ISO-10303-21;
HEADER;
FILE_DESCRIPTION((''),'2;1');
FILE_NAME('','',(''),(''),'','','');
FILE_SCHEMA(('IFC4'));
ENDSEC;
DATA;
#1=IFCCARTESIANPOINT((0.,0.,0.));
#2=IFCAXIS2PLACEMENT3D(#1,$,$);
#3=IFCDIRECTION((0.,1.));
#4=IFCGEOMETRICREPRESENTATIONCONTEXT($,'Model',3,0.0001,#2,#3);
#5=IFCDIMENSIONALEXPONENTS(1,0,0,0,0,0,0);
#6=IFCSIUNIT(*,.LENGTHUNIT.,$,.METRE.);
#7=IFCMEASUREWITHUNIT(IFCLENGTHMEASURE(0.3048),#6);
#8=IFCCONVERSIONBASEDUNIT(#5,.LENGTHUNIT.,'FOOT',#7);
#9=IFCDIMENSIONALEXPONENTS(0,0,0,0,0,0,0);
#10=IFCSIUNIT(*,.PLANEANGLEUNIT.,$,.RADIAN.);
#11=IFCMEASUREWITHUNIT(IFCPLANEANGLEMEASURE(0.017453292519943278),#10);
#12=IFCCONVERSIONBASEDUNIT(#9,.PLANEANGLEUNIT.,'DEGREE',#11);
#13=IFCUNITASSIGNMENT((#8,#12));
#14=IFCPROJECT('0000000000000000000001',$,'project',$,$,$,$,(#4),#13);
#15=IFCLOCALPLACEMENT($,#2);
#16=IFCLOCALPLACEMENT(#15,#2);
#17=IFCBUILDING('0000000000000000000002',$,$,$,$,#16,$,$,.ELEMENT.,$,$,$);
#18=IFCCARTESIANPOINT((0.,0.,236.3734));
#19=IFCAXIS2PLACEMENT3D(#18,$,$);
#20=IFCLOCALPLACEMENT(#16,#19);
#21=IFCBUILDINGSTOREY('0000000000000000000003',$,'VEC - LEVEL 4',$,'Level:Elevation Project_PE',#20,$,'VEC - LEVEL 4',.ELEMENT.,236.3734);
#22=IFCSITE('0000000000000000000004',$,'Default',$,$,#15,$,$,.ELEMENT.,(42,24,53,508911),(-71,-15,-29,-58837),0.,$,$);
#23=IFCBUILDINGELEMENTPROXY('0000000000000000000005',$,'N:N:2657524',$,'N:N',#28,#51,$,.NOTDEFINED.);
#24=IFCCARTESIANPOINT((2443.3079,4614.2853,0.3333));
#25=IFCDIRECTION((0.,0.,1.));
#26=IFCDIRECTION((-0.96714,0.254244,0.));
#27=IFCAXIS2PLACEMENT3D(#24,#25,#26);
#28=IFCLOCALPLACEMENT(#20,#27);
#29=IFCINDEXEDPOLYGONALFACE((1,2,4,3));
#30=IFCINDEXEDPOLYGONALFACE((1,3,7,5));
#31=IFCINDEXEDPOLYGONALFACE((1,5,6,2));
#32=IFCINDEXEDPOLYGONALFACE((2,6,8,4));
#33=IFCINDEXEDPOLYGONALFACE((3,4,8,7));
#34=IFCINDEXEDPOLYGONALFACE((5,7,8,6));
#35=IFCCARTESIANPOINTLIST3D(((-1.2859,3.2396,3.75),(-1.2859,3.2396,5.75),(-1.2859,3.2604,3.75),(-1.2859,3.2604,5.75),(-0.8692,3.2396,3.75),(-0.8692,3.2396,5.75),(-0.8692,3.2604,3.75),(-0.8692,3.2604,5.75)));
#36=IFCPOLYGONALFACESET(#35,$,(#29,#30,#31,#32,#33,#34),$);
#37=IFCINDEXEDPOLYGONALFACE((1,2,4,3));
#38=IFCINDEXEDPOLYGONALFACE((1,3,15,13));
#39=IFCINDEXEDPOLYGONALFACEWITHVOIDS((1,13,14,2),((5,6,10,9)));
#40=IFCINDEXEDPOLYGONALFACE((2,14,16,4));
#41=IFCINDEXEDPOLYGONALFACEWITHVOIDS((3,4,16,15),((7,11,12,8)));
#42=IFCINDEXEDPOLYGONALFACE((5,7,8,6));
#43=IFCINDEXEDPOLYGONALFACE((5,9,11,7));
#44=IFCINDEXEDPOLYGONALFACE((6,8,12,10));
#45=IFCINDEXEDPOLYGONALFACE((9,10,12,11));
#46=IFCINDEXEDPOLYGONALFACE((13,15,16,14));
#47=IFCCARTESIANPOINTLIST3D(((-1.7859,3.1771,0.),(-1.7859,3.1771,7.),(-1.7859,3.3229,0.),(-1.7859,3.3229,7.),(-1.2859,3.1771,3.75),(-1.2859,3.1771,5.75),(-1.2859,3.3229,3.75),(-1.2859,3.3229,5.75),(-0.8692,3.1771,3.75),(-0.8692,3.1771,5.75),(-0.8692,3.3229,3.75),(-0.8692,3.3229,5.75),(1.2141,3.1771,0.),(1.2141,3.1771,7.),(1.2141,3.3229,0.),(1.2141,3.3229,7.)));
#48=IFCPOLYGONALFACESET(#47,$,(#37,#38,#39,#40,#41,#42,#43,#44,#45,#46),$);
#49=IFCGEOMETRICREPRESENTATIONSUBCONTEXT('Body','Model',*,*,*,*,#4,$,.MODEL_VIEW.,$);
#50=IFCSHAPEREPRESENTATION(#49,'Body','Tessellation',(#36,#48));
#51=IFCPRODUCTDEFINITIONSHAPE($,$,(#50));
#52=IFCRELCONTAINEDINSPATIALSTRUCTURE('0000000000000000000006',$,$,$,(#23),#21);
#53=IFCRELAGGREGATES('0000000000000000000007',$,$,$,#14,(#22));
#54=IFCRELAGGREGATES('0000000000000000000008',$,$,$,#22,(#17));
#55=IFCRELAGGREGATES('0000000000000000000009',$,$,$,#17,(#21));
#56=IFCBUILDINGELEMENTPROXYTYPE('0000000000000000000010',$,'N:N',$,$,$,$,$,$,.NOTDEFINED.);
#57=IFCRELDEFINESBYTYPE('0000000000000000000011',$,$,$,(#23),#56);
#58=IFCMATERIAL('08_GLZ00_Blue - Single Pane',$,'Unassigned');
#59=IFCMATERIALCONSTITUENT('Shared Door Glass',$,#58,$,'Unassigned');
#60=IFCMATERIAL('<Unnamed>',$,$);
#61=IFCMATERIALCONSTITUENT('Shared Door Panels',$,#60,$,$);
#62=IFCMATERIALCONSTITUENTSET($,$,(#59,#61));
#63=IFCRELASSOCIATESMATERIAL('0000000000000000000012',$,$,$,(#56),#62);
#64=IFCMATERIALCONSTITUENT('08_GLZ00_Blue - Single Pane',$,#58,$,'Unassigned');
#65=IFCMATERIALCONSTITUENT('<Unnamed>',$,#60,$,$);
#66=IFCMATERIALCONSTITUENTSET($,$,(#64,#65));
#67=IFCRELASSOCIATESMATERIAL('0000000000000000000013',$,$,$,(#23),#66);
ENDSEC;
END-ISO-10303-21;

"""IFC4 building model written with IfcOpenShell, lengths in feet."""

from ifc_helpers import new_model, entity, si_unit, converted_unit, direction, frame, origin, place, context, subcontext, project, spatial, indexed_curve, outline, extrude, source, transform, mapped, material, constituent, constituent_set, type_object, type_shapes, element, save


model = new_model("IFC4")

# Units and contexts
model_context = context("Model", 3, precision=0.0001, world=origin(), true_north=direction((0.0, 1.0)))
body_context = subcontext(model_context, "Body", "Model", "MODEL_VIEW")
ifc_project = project(units=[converted_unit("LENGTHUNIT", "FOOT", entity("IfcLengthMeasure", 0.3048), si_unit("LENGTHUNIT", "METRE"), dimensions=[1, 0, 0, 0, 0, 0, 0]), converted_unit("PLANEANGLEUNIT", "DEGREE", entity("IfcPlaneAngleMeasure", 0.017453292519943278), si_unit("PLANEANGLEUNIT", "RADIAN"), dimensions=[0, 0, 0, 0, 0, 0, 0])], contexts=[model_context])

# Site, building, storey
site_placement = place(None, origin())
site = spatial("IfcSite", under=ifc_project, at=site_placement, Name="Default", CompositionType="ELEMENT", RefLatitude=(42, 24, 53, 508911), RefLongitude=(-71, -15, -29, -58837), RefElevation=0.0)
building_placement = place(site_placement, origin())
building = spatial("IfcBuilding", under=site, at=building_placement, CompositionType="ELEMENT")
storey_placement = place(building_placement, frame((0.0, 0.0, 236.3734)))
storey = spatial("IfcBuildingStorey", under=building, at=storey_placement, Name="VEC - LEVEL 4", ObjectType="Level:Elevation Project_PE", LongName="VEC - LEVEL 4", CompositionType="ELEMENT", Elevation=236.3734)

# Shared definitions
ifc_material_1 = material(Name="<Unnamed>")

# Building element proxy
ifc_material_2 = material(Name="08_GLZ00_Blue - Single Pane", Category="Unassigned")
ifc_constituent_1 = constituent(ifc_material_2, Name="08_GLZ00_Blue - Single Pane", Category="Unassigned")
ifc_constituent_2 = constituent(ifc_material_1, Name="<Unnamed>")
ifc_constituent_set_1 = constituent_set(constituents=[ifc_constituent_1, ifc_constituent_2])
ifc_constituent_3 = constituent(ifc_material_2, Name="Shared Door Glass", Category="Unassigned")
ifc_constituent_4 = constituent(ifc_material_1, Name="Shared Door Panels")
ifc_constituent_set_2 = constituent_set(constituents=[ifc_constituent_3, ifc_constituent_4])
building_element_proxy_type = type_object("IfcBuildingElementProxyType", Name="N:N", PredefinedType="NOTDEFINED", material=ifc_constituent_set_2)
shared_shape = source(origin(), body_context, "Body", "SweptSolid", [
    extrude(outline(indexed_curve([(-0.0104, -0.2083), (0.0104, -0.2083), (0.0104, 0.2083), (-0.0104, 0.2083), (-0.0104, -0.2083)], self_intersect=False)), frame((-1.0775, 3.25, 3.75), z_axis=(0.0, 0.0, 1.0), x_axis=(0.0, 1.0, 0.0)), (0.0, 0.0, 1.0), 2.0),
    extrude(outline(indexed_curve([(-3.5, -1.5), (3.5, -1.5), (3.5, 1.5), (-3.5, 1.5), (-3.5, -1.5)], self_intersect=False), holes=[indexed_curve([(-2.25, 0.5833), (-2.25, 1.0), (-0.25, 1.0), (-0.25, 0.5833), (-2.25, 0.5833)], self_intersect=False)]), frame((-0.2859, 3.1771, 3.5), z_axis=(0.0, 1.0, 0.0), x_axis=(0.0, 0.0, -1.0)), (0.0, 0.0, 1.0), 0.1458),
])
type_shapes(building_element_proxy_type, [shared_shape])
proxy_placement = place(storey_placement, frame((2443.3079, 4614.2853, 0.3333), z_axis=(0.0, 0.0, 1.0), x_axis=(-0.96714, 0.254244, 0.0)))
element("IfcBuildingElementProxy", 1, at=proxy_placement, inside=storey, type_object=building_element_proxy_type, material=ifc_constituent_set_1, Name="N:N:2657524", ObjectType="N:N", PredefinedType="NOTDEFINED", context=body_context, shape_type="MappedRepresentation", body=[
    mapped(shared_shape, transform((0.0, 0.0, 0.0), scale=1.0)),
])

save(model, "model.ifc")
